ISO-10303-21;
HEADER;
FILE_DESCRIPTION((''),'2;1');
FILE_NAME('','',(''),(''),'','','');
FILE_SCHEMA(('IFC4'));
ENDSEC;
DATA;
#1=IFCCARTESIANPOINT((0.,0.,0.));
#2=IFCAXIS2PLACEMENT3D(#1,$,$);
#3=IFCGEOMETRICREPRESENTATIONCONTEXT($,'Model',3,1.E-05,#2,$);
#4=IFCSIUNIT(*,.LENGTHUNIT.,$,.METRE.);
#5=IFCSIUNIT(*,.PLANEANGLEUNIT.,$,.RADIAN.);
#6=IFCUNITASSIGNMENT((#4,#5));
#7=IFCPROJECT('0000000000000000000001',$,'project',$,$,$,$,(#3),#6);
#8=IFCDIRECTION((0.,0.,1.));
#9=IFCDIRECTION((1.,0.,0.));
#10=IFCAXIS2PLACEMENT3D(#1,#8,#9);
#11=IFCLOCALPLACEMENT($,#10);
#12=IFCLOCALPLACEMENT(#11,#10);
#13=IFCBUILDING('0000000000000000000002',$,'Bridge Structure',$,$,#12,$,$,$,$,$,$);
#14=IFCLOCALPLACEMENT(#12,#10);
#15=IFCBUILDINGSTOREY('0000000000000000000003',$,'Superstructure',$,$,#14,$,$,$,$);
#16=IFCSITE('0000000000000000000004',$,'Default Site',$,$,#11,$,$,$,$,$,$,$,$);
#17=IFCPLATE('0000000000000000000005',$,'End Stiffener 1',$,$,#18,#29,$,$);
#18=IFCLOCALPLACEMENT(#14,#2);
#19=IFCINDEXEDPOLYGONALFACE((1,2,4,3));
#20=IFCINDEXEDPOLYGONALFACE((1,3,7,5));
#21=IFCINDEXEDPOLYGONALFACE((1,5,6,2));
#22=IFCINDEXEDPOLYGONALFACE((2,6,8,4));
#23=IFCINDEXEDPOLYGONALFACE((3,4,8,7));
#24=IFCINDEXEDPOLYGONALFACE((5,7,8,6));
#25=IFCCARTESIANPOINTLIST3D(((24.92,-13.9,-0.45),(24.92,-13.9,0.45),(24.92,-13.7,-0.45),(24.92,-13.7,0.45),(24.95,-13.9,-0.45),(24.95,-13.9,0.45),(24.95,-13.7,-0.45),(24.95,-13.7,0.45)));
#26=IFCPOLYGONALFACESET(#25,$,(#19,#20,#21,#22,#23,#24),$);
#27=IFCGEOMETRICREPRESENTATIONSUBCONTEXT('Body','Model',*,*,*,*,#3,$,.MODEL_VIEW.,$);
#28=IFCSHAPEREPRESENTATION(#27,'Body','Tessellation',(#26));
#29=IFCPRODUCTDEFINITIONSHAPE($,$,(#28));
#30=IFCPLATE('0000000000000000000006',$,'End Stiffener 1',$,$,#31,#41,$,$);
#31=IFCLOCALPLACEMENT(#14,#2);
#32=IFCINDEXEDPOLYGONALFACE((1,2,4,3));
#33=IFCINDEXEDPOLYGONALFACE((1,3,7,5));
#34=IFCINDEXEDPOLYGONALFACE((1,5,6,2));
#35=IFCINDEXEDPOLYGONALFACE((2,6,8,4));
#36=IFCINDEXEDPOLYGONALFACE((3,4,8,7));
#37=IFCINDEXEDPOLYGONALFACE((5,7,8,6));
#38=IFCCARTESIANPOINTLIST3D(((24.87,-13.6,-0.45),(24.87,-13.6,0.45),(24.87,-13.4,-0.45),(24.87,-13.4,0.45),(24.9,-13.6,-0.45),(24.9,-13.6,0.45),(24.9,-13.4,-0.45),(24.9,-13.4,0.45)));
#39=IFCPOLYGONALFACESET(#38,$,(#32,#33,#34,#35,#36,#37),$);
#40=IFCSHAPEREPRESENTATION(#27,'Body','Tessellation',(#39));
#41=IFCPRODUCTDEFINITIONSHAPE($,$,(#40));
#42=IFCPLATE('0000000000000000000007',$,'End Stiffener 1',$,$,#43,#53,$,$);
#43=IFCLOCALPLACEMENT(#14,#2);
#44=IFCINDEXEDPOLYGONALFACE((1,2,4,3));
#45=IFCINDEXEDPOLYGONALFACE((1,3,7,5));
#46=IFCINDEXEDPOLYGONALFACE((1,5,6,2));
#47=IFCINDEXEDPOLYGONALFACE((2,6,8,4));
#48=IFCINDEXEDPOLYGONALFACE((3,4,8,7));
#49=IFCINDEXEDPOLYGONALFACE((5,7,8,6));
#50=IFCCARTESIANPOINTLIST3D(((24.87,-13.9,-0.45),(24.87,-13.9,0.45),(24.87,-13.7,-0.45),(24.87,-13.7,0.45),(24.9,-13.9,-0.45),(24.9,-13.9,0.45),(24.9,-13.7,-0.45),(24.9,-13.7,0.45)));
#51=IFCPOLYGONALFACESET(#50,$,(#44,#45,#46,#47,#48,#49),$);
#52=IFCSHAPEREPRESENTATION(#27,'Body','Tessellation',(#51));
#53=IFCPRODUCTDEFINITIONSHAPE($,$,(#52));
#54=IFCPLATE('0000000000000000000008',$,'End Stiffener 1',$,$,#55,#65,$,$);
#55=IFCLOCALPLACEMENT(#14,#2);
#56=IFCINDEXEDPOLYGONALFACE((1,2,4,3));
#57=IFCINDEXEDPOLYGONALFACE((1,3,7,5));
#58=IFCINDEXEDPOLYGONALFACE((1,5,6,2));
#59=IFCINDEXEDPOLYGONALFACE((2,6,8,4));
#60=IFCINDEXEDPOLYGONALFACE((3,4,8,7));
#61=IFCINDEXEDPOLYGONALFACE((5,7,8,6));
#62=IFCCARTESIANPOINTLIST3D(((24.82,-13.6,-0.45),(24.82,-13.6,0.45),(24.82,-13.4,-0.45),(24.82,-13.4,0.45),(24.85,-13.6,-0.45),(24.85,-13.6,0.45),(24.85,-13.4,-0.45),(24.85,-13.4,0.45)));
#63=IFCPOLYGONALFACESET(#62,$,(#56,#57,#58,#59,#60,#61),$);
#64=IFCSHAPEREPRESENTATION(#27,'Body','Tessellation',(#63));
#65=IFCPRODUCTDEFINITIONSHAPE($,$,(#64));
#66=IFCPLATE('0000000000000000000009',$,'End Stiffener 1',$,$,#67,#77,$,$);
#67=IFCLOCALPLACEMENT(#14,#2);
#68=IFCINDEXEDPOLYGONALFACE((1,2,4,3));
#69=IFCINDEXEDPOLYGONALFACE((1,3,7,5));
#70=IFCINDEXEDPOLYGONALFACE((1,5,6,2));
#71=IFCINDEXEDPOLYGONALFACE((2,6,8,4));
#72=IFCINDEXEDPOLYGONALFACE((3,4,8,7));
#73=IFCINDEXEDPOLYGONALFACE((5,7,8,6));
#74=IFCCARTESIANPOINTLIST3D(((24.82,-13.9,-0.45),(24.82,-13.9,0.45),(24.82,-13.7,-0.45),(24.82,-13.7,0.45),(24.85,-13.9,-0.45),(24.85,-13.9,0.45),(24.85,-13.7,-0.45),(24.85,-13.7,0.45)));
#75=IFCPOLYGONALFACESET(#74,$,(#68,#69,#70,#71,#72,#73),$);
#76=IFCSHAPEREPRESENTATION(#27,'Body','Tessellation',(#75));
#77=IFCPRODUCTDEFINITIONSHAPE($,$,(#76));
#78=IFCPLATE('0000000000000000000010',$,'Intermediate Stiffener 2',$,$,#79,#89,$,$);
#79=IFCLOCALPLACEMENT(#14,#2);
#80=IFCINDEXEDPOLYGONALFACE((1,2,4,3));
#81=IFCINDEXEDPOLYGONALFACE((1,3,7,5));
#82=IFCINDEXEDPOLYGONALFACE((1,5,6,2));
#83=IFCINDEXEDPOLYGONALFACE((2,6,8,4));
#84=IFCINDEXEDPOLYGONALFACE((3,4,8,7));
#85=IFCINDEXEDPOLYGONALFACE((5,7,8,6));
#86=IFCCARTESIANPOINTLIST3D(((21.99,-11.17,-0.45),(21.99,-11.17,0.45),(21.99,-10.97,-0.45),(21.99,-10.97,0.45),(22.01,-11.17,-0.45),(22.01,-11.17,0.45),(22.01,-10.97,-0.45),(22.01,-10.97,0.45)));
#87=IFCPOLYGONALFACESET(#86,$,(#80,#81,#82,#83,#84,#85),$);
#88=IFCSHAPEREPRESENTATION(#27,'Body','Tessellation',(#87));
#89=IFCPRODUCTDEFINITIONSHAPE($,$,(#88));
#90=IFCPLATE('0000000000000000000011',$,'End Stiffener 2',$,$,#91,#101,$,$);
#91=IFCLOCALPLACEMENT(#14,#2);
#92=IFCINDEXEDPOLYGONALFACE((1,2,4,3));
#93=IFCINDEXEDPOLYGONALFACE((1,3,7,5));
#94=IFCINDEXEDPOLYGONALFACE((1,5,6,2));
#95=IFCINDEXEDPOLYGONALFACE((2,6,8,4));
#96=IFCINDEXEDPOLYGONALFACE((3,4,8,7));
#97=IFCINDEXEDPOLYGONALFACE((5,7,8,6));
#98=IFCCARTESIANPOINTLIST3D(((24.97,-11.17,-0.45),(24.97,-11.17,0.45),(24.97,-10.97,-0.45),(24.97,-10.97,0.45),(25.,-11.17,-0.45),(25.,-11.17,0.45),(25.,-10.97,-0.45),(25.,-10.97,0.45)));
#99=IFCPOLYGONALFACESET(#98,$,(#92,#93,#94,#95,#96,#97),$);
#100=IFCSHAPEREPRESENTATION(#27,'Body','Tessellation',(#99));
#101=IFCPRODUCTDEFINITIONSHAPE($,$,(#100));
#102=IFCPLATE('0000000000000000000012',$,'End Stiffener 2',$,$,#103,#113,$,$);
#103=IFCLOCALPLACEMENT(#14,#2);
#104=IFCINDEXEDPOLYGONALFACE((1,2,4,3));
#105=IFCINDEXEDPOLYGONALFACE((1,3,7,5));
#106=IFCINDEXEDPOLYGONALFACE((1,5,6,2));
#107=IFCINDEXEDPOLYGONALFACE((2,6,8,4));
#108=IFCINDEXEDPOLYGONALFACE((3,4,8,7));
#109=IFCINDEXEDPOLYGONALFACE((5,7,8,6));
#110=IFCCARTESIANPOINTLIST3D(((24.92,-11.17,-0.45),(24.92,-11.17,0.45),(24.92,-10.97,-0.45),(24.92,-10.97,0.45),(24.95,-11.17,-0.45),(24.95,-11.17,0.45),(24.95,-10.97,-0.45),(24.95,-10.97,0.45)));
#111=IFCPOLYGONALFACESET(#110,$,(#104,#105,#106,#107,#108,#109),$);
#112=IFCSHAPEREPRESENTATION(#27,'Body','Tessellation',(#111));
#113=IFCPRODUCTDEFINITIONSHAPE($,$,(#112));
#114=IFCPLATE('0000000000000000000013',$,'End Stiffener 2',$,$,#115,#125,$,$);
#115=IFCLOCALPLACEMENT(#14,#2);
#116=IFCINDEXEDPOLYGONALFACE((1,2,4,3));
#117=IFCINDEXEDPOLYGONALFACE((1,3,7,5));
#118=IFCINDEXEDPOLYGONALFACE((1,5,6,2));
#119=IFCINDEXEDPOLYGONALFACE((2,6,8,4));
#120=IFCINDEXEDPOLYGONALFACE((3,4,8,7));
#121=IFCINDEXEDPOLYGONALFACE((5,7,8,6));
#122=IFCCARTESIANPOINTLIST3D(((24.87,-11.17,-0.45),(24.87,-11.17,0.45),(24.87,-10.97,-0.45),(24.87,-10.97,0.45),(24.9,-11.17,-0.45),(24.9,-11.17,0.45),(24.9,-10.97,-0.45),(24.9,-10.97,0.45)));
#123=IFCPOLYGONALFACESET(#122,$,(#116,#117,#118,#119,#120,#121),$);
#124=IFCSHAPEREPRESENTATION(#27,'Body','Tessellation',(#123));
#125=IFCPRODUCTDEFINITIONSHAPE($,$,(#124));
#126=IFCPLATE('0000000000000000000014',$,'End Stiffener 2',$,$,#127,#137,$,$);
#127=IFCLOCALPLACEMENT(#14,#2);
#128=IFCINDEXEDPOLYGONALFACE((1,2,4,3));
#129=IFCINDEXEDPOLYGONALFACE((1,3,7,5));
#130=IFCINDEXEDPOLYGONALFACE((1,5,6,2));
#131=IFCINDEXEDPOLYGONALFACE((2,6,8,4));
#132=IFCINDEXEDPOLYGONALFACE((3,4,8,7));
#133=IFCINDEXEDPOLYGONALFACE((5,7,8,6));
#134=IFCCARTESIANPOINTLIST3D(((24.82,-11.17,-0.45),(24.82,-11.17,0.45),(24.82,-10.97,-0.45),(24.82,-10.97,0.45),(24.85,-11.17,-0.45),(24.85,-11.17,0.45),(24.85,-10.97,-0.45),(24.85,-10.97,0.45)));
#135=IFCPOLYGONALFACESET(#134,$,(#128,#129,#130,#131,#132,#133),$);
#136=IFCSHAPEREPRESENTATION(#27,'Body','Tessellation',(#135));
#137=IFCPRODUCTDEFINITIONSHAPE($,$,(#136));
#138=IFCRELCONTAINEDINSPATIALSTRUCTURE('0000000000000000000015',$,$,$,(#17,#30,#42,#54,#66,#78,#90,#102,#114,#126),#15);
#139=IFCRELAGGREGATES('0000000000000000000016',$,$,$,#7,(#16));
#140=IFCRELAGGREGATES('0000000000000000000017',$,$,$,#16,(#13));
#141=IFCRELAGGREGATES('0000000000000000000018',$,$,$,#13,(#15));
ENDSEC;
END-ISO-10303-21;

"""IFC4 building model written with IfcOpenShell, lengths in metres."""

from ifc_helpers import new_model, si_unit, frame, origin, origin_with_axes, origin_2d_with_axis, place, context, subcontext, project, spatial, rectangle, extrude, element, save


model = new_model("IFC4")

# Units and contexts
model_context = context("Model", 3, precision=1e-05, world=origin())
body_context = subcontext(model_context, "Body", "Model", "MODEL_VIEW")
ifc_project = project(units=[si_unit("LENGTHUNIT", "METRE"), si_unit("PLANEANGLEUNIT", "RADIAN")], contexts=[model_context])

# Site, building, storey
site_placement = place(None, origin_with_axes())
site = spatial("IfcSite", under=ifc_project, at=site_placement, Name="Default Site")
building_placement = place(site_placement, origin_with_axes())
building = spatial("IfcBuilding", under=site, at=building_placement, Name="Bridge Structure")
storey_placement = place(building_placement, origin_with_axes())
storey = spatial("IfcBuildingStorey", under=building, at=storey_placement, Name="Superstructure")

# Plates
for number, where, z_axis, x_axis, name in (
    (1, (24.935, -13.8, -0.45), (0.0, 0.0, 1.0), (1.0, 0.0, 0.0), "End Stiffener 1"),
    (2, (24.885, -13.5, -0.45), (0.0, 0.0, 1.0), (1.0, 0.0, 0.0), "End Stiffener 1"),
    (3, (24.885, -13.8, -0.45), (0.0, 0.0, 1.0), (1.0, 0.0, 0.0), "End Stiffener 1"),
    (4, (24.835, -13.5, -0.45), (0.0, 0.0, 1.0), (1.0, 0.0, 0.0), "End Stiffener 1"),
    (5, (24.835, -13.8, -0.45), (0.0, 0.0, 1.0), (1.0, 0.0, 0.0), "End Stiffener 1"),
):
    element("IfcPlate", number, at=place(storey_placement, frame(where, z_axis=z_axis, x_axis=x_axis)), inside=storey, Name=name, context=body_context, shape_type="SweptSolid", body=[
        extrude(rectangle(XDim=0.03, YDim=0.2, at=origin_2d_with_axis()), origin_with_axes(), (0.0, 0.0, 1.0), 0.9),
    ])
plate_placement = place(storey_placement, frame((22.0, -11.07, -0.45), z_axis=(0.0, 0.0, 1.0), x_axis=(1.0, 0.0, 0.0)))
element("IfcPlate", 6, at=plate_placement, inside=storey, Name="Intermediate Stiffener 2", context=body_context, shape_type="SweptSolid", body=[
    extrude(rectangle(XDim=0.02, YDim=0.2, at=origin_2d_with_axis()), origin_with_axes(), (0.0, 0.0, 1.0), 0.9),
])
for number, where, z_axis, x_axis, name in (
    (7, (24.985, -11.07, -0.45), (0.0, 0.0, 1.0), (1.0, 0.0, 0.0), "End Stiffener 2"),
    (8, (24.935, -11.07, -0.45), (0.0, 0.0, 1.0), (1.0, 0.0, 0.0), "End Stiffener 2"),
    (9, (24.885, -11.07, -0.45), (0.0, 0.0, 1.0), (1.0, 0.0, 0.0), "End Stiffener 2"),
    (10, (24.835, -11.07, -0.45), (0.0, 0.0, 1.0), (1.0, 0.0, 0.0), "End Stiffener 2"),
):
    element("IfcPlate", number, at=place(storey_placement, frame(where, z_axis=z_axis, x_axis=x_axis)), inside=storey, Name=name, context=body_context, shape_type="SweptSolid", body=[
        extrude(rectangle(XDim=0.03, YDim=0.2, at=origin_2d_with_axis()), origin_with_axes(), (0.0, 0.0, 1.0), 0.9),
    ])

save(model, "model.ifc")
